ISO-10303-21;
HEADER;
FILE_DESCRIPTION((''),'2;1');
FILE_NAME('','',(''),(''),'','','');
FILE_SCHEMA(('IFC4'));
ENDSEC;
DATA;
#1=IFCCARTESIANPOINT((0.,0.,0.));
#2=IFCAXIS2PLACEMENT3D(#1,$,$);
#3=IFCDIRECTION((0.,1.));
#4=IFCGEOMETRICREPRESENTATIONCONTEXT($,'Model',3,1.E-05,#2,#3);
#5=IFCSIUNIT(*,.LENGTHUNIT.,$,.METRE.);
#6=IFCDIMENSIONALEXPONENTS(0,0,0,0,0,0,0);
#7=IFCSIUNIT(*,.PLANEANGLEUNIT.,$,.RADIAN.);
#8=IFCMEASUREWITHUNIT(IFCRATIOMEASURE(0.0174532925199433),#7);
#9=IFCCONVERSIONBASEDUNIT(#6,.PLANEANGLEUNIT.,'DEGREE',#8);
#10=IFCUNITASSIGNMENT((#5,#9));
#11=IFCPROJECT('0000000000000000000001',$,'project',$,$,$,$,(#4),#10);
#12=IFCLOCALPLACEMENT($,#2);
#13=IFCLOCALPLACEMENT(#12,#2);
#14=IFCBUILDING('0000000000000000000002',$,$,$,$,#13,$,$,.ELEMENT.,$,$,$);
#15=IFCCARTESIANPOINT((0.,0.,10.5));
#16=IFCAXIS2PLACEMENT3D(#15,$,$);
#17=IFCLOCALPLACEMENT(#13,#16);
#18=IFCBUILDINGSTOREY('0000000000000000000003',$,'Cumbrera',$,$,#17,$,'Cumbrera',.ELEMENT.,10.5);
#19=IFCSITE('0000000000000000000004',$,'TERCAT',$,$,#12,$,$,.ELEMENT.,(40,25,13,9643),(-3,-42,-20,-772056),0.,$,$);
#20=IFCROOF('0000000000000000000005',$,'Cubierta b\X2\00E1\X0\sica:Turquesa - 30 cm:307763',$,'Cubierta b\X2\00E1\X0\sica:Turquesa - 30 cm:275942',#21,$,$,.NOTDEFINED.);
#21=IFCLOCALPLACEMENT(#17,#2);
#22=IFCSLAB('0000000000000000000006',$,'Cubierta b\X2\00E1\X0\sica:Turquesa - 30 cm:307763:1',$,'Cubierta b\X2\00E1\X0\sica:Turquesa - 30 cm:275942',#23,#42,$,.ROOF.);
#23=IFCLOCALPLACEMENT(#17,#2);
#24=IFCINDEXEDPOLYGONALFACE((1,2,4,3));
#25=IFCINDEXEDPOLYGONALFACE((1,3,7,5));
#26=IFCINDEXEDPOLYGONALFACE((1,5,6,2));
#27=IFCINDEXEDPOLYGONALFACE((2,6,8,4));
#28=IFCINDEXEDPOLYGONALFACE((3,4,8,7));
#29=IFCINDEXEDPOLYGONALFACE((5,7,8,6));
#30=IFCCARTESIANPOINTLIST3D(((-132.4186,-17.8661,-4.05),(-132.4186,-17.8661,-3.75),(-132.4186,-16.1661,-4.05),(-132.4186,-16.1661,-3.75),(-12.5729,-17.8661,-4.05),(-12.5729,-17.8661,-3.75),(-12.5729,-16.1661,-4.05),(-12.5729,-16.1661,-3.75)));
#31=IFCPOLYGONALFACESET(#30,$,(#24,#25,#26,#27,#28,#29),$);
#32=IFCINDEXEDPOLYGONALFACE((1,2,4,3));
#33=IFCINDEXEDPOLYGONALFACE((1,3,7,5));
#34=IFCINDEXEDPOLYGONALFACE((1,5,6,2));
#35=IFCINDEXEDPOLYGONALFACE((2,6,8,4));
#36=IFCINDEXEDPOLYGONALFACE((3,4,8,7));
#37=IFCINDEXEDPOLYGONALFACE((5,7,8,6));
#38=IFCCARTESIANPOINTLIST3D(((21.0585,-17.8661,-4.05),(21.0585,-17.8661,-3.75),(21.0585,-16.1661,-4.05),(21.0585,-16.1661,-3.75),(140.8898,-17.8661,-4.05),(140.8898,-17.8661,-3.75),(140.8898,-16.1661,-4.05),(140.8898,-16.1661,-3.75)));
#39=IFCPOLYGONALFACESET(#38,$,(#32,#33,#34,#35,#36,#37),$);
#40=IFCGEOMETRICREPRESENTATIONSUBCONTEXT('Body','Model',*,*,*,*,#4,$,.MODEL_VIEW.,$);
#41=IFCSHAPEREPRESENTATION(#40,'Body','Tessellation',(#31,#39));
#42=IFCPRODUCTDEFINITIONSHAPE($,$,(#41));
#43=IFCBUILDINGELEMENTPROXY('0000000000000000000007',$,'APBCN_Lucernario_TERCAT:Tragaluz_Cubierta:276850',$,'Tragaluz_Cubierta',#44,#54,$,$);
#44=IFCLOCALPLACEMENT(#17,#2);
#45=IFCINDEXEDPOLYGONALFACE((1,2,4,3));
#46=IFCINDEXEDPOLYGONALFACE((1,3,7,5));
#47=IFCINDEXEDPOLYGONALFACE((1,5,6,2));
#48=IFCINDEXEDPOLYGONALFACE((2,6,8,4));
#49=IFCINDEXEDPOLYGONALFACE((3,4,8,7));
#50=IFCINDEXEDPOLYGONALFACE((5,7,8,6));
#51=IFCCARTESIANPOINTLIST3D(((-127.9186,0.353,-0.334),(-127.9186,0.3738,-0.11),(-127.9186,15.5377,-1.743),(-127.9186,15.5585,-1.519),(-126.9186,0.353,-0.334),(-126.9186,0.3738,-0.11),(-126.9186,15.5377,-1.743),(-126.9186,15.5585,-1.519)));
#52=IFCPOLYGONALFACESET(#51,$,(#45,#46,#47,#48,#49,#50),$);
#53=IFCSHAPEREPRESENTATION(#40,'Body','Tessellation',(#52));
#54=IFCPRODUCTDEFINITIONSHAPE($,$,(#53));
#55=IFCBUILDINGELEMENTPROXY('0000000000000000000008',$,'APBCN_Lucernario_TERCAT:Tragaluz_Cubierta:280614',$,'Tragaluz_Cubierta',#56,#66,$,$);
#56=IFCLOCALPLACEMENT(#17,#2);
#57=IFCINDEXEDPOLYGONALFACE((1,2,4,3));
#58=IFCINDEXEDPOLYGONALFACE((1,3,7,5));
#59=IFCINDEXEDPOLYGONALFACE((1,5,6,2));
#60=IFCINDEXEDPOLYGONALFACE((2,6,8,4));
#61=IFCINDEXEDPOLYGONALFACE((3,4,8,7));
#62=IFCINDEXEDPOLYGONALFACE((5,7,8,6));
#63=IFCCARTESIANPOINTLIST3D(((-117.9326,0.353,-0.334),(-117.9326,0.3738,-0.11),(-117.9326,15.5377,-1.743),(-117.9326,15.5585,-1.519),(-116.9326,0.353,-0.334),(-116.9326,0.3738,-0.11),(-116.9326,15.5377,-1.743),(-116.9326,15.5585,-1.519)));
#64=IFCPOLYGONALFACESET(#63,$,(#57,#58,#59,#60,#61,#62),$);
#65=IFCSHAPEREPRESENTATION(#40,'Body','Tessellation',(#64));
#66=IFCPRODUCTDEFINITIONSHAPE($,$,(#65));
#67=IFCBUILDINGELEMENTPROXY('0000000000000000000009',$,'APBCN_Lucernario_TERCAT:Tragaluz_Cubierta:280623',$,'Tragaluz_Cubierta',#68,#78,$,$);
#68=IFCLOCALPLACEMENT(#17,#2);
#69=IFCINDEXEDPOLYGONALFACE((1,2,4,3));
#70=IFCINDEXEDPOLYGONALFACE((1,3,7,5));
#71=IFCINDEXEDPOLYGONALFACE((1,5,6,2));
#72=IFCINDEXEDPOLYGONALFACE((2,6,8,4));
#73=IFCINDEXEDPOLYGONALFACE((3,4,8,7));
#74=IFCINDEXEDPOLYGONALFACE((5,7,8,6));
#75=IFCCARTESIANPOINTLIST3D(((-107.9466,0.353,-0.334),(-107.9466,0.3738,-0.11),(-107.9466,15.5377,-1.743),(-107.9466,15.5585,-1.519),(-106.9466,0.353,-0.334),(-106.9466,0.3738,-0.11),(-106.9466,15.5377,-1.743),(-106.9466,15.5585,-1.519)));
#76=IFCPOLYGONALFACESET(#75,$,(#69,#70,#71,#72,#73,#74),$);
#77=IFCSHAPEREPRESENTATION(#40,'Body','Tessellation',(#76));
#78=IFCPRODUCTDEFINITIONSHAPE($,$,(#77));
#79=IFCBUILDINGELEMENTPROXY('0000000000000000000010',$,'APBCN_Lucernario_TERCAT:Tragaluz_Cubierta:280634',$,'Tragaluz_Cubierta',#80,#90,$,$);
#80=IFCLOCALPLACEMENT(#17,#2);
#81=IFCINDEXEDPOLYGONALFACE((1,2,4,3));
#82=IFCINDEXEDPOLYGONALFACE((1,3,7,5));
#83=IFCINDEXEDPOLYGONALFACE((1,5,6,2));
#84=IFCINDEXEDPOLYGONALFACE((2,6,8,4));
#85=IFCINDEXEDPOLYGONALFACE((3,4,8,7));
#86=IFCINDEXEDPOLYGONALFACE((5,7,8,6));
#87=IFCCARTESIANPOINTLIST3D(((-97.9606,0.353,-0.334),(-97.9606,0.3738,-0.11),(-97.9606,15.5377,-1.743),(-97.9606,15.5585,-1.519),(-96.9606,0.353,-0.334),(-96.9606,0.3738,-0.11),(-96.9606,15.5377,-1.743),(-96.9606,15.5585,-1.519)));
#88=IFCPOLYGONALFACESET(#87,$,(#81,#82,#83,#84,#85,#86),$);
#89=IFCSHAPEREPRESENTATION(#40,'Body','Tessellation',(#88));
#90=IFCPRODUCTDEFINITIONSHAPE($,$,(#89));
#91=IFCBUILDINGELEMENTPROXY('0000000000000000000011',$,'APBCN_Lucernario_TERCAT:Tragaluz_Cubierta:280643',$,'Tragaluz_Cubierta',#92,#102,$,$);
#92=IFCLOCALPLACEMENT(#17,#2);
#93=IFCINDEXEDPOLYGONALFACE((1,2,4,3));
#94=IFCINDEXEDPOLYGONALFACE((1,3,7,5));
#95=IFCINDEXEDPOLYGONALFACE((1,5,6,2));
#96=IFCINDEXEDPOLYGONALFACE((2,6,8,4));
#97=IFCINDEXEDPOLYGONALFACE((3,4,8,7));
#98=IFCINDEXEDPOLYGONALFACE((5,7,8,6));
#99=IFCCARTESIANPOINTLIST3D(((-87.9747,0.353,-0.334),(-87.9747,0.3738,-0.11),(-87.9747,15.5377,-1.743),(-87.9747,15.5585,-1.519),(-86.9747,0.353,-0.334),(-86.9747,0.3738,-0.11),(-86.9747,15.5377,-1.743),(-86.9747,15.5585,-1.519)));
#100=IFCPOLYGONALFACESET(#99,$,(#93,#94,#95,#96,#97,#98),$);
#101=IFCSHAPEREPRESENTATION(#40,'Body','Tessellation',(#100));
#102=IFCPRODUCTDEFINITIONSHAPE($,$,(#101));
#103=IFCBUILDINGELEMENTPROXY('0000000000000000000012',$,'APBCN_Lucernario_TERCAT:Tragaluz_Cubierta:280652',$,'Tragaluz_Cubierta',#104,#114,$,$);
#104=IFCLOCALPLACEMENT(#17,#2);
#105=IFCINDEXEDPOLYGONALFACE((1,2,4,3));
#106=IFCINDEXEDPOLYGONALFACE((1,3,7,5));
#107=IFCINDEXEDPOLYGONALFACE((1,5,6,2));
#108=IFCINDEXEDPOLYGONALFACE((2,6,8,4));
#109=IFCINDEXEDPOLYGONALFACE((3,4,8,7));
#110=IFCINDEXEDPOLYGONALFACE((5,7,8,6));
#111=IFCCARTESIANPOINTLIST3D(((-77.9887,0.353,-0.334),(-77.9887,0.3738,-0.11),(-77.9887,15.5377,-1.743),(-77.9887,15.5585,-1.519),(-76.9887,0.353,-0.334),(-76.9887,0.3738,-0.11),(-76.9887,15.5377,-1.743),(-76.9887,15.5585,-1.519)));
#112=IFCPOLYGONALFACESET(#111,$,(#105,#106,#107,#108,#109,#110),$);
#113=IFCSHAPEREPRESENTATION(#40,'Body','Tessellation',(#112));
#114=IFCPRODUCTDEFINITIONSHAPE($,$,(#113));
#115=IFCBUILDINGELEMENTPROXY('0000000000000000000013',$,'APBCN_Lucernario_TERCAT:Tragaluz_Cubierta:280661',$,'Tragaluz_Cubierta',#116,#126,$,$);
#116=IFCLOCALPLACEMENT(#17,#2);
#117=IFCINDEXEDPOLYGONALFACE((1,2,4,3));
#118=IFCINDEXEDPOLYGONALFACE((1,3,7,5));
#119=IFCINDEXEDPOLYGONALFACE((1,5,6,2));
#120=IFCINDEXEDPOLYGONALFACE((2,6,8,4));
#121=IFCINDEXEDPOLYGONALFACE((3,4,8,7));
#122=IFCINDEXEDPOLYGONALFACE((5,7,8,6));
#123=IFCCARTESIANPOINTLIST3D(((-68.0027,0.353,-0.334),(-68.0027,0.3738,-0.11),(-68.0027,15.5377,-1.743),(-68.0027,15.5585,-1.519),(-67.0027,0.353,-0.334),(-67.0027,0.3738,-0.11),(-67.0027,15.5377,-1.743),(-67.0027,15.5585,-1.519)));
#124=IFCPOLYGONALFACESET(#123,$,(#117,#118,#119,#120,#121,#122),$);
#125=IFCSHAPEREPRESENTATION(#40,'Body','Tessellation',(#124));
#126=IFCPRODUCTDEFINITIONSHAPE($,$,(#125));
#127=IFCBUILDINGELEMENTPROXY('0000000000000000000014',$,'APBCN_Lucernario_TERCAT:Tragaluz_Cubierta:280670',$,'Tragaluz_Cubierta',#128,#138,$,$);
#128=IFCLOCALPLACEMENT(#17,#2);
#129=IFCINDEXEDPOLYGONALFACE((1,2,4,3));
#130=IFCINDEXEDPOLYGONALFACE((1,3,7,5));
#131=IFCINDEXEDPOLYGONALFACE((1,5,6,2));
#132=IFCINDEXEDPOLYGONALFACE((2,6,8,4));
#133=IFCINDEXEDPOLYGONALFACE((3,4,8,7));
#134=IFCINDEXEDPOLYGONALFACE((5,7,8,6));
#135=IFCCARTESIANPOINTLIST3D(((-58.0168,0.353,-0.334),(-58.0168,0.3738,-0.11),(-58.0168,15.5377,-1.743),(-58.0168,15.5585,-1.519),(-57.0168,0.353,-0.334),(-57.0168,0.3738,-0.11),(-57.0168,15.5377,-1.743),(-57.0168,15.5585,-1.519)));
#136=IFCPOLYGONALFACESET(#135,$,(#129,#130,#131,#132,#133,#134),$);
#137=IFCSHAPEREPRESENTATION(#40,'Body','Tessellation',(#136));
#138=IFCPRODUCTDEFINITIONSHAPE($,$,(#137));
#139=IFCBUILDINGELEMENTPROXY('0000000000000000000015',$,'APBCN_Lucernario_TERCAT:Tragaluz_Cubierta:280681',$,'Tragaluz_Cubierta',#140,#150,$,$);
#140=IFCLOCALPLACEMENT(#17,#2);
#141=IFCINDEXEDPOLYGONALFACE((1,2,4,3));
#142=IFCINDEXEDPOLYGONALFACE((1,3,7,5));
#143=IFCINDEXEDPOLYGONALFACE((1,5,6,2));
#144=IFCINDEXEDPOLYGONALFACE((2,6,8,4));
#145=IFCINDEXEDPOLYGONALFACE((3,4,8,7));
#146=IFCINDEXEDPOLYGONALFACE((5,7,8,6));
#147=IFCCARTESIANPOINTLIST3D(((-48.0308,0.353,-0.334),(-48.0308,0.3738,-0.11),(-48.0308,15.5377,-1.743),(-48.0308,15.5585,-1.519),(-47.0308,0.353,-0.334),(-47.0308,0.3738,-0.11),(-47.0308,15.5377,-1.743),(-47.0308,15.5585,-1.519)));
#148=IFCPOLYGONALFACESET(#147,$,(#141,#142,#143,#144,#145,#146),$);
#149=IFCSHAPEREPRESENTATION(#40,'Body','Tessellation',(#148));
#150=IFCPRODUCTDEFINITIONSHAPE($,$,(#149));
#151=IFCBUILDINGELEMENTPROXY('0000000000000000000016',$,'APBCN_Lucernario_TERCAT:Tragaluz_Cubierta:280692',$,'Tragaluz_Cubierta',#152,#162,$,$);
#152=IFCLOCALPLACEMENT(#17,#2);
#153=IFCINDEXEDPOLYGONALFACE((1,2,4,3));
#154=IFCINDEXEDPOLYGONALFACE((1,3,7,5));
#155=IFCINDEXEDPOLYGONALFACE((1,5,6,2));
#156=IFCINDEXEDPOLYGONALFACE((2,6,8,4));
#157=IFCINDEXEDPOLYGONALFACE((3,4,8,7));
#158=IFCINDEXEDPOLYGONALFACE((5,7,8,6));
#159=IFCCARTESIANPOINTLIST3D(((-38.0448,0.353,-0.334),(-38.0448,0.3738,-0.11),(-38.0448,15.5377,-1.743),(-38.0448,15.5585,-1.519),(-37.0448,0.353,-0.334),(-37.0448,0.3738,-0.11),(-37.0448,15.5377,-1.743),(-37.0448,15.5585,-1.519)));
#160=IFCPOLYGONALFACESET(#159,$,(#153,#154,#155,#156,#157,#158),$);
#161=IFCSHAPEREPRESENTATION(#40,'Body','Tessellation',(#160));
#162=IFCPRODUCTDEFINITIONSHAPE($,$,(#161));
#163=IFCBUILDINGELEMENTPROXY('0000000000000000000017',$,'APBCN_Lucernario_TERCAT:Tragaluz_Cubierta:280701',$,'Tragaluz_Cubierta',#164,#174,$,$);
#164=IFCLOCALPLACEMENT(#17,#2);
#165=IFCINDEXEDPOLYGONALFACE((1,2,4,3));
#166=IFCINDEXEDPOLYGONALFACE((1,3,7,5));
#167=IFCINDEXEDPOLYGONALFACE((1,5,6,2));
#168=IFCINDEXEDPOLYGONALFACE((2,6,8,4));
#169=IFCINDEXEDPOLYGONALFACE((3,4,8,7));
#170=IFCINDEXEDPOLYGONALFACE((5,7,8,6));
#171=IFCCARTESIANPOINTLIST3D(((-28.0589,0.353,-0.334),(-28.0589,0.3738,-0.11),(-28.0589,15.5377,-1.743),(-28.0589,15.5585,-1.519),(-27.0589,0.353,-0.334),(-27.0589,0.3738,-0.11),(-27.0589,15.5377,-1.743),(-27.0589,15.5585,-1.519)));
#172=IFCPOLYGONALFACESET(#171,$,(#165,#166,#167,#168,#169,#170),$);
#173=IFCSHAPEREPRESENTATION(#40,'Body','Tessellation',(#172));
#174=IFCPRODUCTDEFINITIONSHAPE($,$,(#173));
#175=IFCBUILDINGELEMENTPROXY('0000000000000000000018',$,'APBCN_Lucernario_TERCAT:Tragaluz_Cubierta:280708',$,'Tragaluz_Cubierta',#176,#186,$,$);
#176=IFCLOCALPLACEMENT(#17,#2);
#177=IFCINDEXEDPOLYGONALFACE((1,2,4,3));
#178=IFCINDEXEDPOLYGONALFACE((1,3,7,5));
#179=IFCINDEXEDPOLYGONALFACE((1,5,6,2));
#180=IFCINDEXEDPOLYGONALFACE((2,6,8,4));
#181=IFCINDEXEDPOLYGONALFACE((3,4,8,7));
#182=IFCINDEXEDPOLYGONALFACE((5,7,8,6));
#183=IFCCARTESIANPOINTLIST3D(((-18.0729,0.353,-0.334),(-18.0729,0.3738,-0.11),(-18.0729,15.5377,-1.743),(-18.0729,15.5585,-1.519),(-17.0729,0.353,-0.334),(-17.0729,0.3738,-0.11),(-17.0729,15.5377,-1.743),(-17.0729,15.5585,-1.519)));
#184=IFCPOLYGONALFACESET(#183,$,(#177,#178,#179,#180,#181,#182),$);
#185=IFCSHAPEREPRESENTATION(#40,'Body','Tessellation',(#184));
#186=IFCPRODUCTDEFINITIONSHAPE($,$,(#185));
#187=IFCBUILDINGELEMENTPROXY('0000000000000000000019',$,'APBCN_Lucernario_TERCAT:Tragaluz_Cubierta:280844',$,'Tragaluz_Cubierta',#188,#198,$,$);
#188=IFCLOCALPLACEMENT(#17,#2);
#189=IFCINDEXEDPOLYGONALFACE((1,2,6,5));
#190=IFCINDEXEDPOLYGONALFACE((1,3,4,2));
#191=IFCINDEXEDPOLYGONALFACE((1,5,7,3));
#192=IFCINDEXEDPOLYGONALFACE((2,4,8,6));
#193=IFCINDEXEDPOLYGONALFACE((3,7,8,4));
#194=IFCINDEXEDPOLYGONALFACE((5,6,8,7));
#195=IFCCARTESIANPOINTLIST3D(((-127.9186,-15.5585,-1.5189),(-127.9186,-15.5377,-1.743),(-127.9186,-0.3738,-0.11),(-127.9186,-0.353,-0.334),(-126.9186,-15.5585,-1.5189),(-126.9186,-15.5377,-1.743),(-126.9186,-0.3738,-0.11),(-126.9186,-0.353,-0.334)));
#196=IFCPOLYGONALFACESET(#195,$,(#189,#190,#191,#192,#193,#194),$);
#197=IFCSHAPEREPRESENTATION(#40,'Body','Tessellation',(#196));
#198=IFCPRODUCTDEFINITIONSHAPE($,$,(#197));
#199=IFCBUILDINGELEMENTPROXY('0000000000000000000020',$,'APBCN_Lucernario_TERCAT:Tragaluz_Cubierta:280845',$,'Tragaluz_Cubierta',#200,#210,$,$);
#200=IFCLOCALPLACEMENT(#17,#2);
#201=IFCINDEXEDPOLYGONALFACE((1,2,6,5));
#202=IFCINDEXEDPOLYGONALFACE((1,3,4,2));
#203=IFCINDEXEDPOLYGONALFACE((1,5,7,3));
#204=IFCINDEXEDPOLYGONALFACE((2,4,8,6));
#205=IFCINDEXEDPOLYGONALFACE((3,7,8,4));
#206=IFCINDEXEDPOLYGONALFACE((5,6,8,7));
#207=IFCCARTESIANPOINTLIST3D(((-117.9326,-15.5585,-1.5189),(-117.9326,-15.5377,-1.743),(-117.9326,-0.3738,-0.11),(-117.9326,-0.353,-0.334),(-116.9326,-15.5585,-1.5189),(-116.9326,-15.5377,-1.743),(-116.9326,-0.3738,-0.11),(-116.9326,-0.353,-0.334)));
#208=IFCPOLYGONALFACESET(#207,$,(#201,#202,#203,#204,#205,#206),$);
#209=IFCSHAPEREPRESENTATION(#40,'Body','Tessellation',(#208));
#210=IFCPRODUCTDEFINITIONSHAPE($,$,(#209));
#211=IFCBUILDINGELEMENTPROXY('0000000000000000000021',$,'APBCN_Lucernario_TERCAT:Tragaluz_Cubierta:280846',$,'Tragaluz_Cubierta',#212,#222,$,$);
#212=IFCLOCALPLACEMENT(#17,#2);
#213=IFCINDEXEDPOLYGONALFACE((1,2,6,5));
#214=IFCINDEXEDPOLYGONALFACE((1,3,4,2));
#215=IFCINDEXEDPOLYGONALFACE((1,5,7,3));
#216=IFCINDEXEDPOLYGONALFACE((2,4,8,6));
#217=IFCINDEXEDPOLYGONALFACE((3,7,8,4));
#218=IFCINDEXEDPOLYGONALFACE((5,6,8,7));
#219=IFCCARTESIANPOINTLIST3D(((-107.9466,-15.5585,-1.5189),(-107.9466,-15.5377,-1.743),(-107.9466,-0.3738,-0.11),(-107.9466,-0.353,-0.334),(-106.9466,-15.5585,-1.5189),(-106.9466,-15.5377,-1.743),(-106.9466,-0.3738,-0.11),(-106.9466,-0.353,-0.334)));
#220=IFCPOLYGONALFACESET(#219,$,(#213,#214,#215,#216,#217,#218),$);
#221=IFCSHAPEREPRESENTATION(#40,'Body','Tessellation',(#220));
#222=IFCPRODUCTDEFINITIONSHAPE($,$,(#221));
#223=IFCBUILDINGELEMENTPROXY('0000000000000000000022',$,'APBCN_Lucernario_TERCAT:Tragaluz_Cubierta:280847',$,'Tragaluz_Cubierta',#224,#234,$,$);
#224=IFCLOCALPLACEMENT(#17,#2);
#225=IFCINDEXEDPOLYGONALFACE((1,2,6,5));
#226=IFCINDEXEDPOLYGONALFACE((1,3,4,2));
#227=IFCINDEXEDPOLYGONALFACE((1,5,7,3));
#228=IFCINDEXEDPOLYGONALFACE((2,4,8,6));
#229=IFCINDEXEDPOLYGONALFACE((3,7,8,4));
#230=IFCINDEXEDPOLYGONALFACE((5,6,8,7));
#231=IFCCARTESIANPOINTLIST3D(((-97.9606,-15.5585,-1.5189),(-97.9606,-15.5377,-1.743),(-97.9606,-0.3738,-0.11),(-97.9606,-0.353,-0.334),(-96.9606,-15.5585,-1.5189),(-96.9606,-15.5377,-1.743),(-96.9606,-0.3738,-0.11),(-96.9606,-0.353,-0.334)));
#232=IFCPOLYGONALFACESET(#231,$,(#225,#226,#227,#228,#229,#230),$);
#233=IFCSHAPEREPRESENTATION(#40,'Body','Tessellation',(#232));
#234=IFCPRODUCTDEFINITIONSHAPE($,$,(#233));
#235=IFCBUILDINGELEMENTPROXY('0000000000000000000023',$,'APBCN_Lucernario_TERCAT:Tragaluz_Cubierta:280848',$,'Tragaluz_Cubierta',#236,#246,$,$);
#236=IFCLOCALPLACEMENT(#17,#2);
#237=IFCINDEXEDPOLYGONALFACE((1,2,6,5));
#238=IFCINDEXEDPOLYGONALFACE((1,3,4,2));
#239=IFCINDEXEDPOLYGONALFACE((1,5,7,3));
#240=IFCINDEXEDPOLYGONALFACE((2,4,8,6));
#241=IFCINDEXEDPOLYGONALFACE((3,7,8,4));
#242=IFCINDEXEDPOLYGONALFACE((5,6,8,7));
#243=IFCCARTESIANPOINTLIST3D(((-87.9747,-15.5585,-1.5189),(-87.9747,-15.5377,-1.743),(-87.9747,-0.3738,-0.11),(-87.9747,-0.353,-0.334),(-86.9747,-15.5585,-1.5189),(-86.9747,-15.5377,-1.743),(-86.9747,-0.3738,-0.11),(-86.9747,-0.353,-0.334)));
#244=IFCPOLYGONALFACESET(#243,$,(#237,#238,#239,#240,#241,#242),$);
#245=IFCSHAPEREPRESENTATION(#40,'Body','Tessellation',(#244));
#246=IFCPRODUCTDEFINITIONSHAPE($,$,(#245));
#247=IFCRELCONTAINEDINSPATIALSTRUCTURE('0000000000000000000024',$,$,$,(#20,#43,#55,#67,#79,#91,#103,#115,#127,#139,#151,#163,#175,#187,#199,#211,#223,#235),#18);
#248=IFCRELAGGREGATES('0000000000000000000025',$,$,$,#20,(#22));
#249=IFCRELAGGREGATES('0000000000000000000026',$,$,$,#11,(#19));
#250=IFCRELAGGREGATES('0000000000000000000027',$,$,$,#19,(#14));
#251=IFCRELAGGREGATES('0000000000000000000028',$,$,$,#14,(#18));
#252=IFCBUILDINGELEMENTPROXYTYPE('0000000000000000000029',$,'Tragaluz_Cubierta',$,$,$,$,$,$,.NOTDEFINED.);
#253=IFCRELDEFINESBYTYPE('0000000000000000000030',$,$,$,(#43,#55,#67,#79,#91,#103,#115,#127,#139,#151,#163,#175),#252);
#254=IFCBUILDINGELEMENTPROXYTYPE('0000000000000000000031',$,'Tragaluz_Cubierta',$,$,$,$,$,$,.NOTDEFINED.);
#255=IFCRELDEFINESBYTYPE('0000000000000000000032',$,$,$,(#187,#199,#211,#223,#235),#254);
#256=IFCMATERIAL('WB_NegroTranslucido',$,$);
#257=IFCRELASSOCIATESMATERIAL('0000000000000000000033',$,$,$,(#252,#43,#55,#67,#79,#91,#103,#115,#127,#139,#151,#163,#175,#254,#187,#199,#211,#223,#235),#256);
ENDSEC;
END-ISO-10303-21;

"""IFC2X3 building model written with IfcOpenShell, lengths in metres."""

from ifc_helpers import new_model, entity, si_unit, converted_unit, direction, frame, frame_2d, origin, origin_2d_with_axis, place, context, subcontext, project, spatial, rectangle, extrude, source, transform, mapped, material, type_object, type_shapes, element, aggregate, save


model = new_model("IFC2X3")

# Units and contexts
model_context = context("Model", 3, precision=1e-05, world=origin(), true_north=direction((0.0, 1.0)))
body_context = subcontext(model_context, "Body", "Model", "MODEL_VIEW")
ifc_project = project(units=[si_unit("LENGTHUNIT", "METRE"), converted_unit("PLANEANGLEUNIT", "DEGREE", entity("IfcRatioMeasure", 0.0174532925199433), si_unit("PLANEANGLEUNIT", "RADIAN"), dimensions=[0, 0, 0, 0, 0, 0, 0])], contexts=[model_context])

# Site, building, storey
site_placement = place(None, origin())
site = spatial("IfcSite", under=ifc_project, at=site_placement, Name="TERCAT", CompositionType="ELEMENT", RefLatitude=(40, 25, 13, 9643), RefLongitude=(-3, -42, -20, -772056), RefElevation=0.0)
building_placement = place(site_placement, origin())
building = spatial("IfcBuilding", under=site, at=building_placement, CompositionType="ELEMENT")
storey_placement = place(building_placement, frame((0.0, 0.0, 10.5)))
storey = spatial("IfcBuildingStorey", under=building, at=storey_placement, Name="Cumbrera", LongName="Cumbrera", CompositionType="ELEMENT", Elevation=10.5)

# Roof, slab
roof_1_placement = place(storey_placement, frame((-132.4186, -17.8661, -4.05)))
roof_1 = element("IfcRoof", 1, at=roof_1_placement, inside=storey, Name="Cubierta básica:Turquesa - 30 cm:307763", ObjectType="Cubierta básica:Turquesa - 30 cm:275942", ShapeType="NOTDEFINED")
slab_1_placement = place(storey_placement, frame((-132.4186, -17.8661, -4.05)))
slab_1 = element("IfcSlab", 2, at=slab_1_placement, Name="Cubierta básica:Turquesa - 30 cm:307763:1", ObjectType="Cubierta básica:Turquesa - 30 cm:275942", PredefinedType="ROOF", context=body_context, shape_type="SweptSolid", body=[
    extrude(rectangle(XDim=1.7, YDim=119.8457, at=origin_2d_with_axis()), frame((59.9228, 0.85, 0.0), z_axis=(0.0, 0.0, 1.0), x_axis=(0.0, 1.0, 0.0)), (0.0, 0.0, 1.0), 0.3),
    extrude(rectangle(XDim=119.8313, YDim=1.7, at=frame_2d((0.0, 0.0), x_axis=(1.0, 0.0))), frame((213.3927, 0.85, 0.0)), (0.0, 0.0, 1.0), 0.3),
])
aggregate(roof_1, [slab_1])

# Building element proxies
ifc_material_1 = material(Name="WB_NegroTranslucido")
building_element_proxy_type_1 = type_object("IfcBuildingElementProxyType", Name="Tragaluz_Cubierta", PredefinedType="NOTDEFINED", material=ifc_material_1)
shared_shape_1 = source(origin(), body_context, "Body", "SweptSolid", [
    extrude(rectangle(XDim=1.0, YDim=15.25, at=origin_2d_with_axis()), frame((0.5, 7.625, 0.0), z_axis=(0.0, 0.0, 1.0), x_axis=(-1.0, 0.0, 0.0)), (0.0, 0.0, 1.0), 0.225),
])
type_shapes(building_element_proxy_type_1, [shared_shape_1])
for number, where, z_axis, x_axis, name in (
    (3, (-126.9186, 15.5377, -1.743), (0.0, 0.092394, 0.995723), (-1.0, 0.0, 0.0), "APBCN_Lucernario_TERCAT:Tragaluz_Cubierta:276850"),
    (4, (-116.9326, 15.5377, -1.743), (0.0, 0.092394, 0.995723), (-1.0, 0.0, 0.0), "APBCN_Lucernario_TERCAT:Tragaluz_Cubierta:280614"),
    (5, (-106.9466, 15.5377, -1.743), (0.0, 0.092394, 0.995723), (-1.0, 0.0, 0.0), "APBCN_Lucernario_TERCAT:Tragaluz_Cubierta:280623"),
    (6, (-96.9606, 15.5377, -1.743), (0.0, 0.092394, 0.995723), (-1.0, 0.0, 0.0), "APBCN_Lucernario_TERCAT:Tragaluz_Cubierta:280634"),
    (7, (-86.9747, 15.5377, -1.743), (0.0, 0.092394, 0.995723), (-1.0, 0.0, 0.0), "APBCN_Lucernario_TERCAT:Tragaluz_Cubierta:280643"),
    (8, (-76.9887, 15.5377, -1.743), (0.0, 0.092394, 0.995723), (-1.0, 0.0, 0.0), "APBCN_Lucernario_TERCAT:Tragaluz_Cubierta:280652"),
    (9, (-67.0027, 15.5377, -1.743), (0.0, 0.092394, 0.995723), (-1.0, 0.0, 0.0), "APBCN_Lucernario_TERCAT:Tragaluz_Cubierta:280661"),
    (10, (-57.0168, 15.5377, -1.743), (0.0, 0.092394, 0.995723), (-1.0, 0.0, 0.0), "APBCN_Lucernario_TERCAT:Tragaluz_Cubierta:280670"),
    (11, (-47.0308, 15.5377, -1.743), (0.0, 0.092394, 0.995723), (-1.0, 0.0, 0.0), "APBCN_Lucernario_TERCAT:Tragaluz_Cubierta:280681"),
    (12, (-37.0448, 15.5377, -1.743), (0.0, 0.092394, 0.995723), (-1.0, 0.0, 0.0), "APBCN_Lucernario_TERCAT:Tragaluz_Cubierta:280692"),
    (13, (-27.0589, 15.5377, -1.743), (0.0, 0.092394, 0.995723), (-1.0, 0.0, 0.0), "APBCN_Lucernario_TERCAT:Tragaluz_Cubierta:280701"),
    (14, (-17.0729, 15.5377, -1.743), (0.0, 0.092394, 0.995723), (-1.0, 0.0, 0.0), "APBCN_Lucernario_TERCAT:Tragaluz_Cubierta:280708"),
):
    element("IfcBuildingElementProxy", number, at=place(storey_placement, frame(where, z_axis=z_axis, x_axis=x_axis)), inside=storey, type_object=building_element_proxy_type_1, material=ifc_material_1, Name=name, ObjectType="Tragaluz_Cubierta", context=body_context, shape_type="MappedRepresentation", body=[
        mapped(shared_shape_1, transform((0.0, 0.0, 0.0), scale=1.0)),
    ])
building_element_proxy_type_2 = type_object("IfcBuildingElementProxyType", Name="Tragaluz_Cubierta", PredefinedType="NOTDEFINED", material=ifc_material_1)
shared_shape_2 = source(origin(), body_context, "Body", "SweptSolid", [
    extrude(rectangle(XDim=15.25, YDim=1.0, at=origin_2d_with_axis()), frame((0.5, 7.625, 0.0), z_axis=(0.0, 0.0, 1.0), x_axis=(0.0, 1.0, 0.0)), (0.0, 0.0, 1.0), 0.225),
])
type_shapes(building_element_proxy_type_2, [shared_shape_2])
for number, where, z_axis, x_axis, name in (
    (15, (-126.9186, -0.353, -0.334), (0.0, -0.09239, 0.995723), (-1.0, 0.0, 0.0), "APBCN_Lucernario_TERCAT:Tragaluz_Cubierta:280844"),
    (16, (-116.9326, -0.353, -0.334), (0.0, -0.09239, 0.995723), (-1.0, 0.0, 0.0), "APBCN_Lucernario_TERCAT:Tragaluz_Cubierta:280845"),
    (17, (-106.9466, -0.353, -0.334), (0.0, -0.09239, 0.995723), (-1.0, 0.0, 0.0), "APBCN_Lucernario_TERCAT:Tragaluz_Cubierta:280846"),
    (18, (-96.9606, -0.353, -0.334), (0.0, -0.09239, 0.995723), (-1.0, 0.0, 0.0), "APBCN_Lucernario_TERCAT:Tragaluz_Cubierta:280847"),
    (19, (-86.9747, -0.353, -0.334), (0.0, -0.09239, 0.995723), (-1.0, 0.0, 0.0), "APBCN_Lucernario_TERCAT:Tragaluz_Cubierta:280848"),
):
    element("IfcBuildingElementProxy", number, at=place(storey_placement, frame(where, z_axis=z_axis, x_axis=x_axis)), inside=storey, type_object=building_element_proxy_type_2, material=ifc_material_1, Name=name, ObjectType="Tragaluz_Cubierta", context=body_context, shape_type="MappedRepresentation", body=[
        mapped(shared_shape_2, transform((0.0, 0.0, 0.0), scale=1.0)),
    ])

save(model, "model.ifc")
